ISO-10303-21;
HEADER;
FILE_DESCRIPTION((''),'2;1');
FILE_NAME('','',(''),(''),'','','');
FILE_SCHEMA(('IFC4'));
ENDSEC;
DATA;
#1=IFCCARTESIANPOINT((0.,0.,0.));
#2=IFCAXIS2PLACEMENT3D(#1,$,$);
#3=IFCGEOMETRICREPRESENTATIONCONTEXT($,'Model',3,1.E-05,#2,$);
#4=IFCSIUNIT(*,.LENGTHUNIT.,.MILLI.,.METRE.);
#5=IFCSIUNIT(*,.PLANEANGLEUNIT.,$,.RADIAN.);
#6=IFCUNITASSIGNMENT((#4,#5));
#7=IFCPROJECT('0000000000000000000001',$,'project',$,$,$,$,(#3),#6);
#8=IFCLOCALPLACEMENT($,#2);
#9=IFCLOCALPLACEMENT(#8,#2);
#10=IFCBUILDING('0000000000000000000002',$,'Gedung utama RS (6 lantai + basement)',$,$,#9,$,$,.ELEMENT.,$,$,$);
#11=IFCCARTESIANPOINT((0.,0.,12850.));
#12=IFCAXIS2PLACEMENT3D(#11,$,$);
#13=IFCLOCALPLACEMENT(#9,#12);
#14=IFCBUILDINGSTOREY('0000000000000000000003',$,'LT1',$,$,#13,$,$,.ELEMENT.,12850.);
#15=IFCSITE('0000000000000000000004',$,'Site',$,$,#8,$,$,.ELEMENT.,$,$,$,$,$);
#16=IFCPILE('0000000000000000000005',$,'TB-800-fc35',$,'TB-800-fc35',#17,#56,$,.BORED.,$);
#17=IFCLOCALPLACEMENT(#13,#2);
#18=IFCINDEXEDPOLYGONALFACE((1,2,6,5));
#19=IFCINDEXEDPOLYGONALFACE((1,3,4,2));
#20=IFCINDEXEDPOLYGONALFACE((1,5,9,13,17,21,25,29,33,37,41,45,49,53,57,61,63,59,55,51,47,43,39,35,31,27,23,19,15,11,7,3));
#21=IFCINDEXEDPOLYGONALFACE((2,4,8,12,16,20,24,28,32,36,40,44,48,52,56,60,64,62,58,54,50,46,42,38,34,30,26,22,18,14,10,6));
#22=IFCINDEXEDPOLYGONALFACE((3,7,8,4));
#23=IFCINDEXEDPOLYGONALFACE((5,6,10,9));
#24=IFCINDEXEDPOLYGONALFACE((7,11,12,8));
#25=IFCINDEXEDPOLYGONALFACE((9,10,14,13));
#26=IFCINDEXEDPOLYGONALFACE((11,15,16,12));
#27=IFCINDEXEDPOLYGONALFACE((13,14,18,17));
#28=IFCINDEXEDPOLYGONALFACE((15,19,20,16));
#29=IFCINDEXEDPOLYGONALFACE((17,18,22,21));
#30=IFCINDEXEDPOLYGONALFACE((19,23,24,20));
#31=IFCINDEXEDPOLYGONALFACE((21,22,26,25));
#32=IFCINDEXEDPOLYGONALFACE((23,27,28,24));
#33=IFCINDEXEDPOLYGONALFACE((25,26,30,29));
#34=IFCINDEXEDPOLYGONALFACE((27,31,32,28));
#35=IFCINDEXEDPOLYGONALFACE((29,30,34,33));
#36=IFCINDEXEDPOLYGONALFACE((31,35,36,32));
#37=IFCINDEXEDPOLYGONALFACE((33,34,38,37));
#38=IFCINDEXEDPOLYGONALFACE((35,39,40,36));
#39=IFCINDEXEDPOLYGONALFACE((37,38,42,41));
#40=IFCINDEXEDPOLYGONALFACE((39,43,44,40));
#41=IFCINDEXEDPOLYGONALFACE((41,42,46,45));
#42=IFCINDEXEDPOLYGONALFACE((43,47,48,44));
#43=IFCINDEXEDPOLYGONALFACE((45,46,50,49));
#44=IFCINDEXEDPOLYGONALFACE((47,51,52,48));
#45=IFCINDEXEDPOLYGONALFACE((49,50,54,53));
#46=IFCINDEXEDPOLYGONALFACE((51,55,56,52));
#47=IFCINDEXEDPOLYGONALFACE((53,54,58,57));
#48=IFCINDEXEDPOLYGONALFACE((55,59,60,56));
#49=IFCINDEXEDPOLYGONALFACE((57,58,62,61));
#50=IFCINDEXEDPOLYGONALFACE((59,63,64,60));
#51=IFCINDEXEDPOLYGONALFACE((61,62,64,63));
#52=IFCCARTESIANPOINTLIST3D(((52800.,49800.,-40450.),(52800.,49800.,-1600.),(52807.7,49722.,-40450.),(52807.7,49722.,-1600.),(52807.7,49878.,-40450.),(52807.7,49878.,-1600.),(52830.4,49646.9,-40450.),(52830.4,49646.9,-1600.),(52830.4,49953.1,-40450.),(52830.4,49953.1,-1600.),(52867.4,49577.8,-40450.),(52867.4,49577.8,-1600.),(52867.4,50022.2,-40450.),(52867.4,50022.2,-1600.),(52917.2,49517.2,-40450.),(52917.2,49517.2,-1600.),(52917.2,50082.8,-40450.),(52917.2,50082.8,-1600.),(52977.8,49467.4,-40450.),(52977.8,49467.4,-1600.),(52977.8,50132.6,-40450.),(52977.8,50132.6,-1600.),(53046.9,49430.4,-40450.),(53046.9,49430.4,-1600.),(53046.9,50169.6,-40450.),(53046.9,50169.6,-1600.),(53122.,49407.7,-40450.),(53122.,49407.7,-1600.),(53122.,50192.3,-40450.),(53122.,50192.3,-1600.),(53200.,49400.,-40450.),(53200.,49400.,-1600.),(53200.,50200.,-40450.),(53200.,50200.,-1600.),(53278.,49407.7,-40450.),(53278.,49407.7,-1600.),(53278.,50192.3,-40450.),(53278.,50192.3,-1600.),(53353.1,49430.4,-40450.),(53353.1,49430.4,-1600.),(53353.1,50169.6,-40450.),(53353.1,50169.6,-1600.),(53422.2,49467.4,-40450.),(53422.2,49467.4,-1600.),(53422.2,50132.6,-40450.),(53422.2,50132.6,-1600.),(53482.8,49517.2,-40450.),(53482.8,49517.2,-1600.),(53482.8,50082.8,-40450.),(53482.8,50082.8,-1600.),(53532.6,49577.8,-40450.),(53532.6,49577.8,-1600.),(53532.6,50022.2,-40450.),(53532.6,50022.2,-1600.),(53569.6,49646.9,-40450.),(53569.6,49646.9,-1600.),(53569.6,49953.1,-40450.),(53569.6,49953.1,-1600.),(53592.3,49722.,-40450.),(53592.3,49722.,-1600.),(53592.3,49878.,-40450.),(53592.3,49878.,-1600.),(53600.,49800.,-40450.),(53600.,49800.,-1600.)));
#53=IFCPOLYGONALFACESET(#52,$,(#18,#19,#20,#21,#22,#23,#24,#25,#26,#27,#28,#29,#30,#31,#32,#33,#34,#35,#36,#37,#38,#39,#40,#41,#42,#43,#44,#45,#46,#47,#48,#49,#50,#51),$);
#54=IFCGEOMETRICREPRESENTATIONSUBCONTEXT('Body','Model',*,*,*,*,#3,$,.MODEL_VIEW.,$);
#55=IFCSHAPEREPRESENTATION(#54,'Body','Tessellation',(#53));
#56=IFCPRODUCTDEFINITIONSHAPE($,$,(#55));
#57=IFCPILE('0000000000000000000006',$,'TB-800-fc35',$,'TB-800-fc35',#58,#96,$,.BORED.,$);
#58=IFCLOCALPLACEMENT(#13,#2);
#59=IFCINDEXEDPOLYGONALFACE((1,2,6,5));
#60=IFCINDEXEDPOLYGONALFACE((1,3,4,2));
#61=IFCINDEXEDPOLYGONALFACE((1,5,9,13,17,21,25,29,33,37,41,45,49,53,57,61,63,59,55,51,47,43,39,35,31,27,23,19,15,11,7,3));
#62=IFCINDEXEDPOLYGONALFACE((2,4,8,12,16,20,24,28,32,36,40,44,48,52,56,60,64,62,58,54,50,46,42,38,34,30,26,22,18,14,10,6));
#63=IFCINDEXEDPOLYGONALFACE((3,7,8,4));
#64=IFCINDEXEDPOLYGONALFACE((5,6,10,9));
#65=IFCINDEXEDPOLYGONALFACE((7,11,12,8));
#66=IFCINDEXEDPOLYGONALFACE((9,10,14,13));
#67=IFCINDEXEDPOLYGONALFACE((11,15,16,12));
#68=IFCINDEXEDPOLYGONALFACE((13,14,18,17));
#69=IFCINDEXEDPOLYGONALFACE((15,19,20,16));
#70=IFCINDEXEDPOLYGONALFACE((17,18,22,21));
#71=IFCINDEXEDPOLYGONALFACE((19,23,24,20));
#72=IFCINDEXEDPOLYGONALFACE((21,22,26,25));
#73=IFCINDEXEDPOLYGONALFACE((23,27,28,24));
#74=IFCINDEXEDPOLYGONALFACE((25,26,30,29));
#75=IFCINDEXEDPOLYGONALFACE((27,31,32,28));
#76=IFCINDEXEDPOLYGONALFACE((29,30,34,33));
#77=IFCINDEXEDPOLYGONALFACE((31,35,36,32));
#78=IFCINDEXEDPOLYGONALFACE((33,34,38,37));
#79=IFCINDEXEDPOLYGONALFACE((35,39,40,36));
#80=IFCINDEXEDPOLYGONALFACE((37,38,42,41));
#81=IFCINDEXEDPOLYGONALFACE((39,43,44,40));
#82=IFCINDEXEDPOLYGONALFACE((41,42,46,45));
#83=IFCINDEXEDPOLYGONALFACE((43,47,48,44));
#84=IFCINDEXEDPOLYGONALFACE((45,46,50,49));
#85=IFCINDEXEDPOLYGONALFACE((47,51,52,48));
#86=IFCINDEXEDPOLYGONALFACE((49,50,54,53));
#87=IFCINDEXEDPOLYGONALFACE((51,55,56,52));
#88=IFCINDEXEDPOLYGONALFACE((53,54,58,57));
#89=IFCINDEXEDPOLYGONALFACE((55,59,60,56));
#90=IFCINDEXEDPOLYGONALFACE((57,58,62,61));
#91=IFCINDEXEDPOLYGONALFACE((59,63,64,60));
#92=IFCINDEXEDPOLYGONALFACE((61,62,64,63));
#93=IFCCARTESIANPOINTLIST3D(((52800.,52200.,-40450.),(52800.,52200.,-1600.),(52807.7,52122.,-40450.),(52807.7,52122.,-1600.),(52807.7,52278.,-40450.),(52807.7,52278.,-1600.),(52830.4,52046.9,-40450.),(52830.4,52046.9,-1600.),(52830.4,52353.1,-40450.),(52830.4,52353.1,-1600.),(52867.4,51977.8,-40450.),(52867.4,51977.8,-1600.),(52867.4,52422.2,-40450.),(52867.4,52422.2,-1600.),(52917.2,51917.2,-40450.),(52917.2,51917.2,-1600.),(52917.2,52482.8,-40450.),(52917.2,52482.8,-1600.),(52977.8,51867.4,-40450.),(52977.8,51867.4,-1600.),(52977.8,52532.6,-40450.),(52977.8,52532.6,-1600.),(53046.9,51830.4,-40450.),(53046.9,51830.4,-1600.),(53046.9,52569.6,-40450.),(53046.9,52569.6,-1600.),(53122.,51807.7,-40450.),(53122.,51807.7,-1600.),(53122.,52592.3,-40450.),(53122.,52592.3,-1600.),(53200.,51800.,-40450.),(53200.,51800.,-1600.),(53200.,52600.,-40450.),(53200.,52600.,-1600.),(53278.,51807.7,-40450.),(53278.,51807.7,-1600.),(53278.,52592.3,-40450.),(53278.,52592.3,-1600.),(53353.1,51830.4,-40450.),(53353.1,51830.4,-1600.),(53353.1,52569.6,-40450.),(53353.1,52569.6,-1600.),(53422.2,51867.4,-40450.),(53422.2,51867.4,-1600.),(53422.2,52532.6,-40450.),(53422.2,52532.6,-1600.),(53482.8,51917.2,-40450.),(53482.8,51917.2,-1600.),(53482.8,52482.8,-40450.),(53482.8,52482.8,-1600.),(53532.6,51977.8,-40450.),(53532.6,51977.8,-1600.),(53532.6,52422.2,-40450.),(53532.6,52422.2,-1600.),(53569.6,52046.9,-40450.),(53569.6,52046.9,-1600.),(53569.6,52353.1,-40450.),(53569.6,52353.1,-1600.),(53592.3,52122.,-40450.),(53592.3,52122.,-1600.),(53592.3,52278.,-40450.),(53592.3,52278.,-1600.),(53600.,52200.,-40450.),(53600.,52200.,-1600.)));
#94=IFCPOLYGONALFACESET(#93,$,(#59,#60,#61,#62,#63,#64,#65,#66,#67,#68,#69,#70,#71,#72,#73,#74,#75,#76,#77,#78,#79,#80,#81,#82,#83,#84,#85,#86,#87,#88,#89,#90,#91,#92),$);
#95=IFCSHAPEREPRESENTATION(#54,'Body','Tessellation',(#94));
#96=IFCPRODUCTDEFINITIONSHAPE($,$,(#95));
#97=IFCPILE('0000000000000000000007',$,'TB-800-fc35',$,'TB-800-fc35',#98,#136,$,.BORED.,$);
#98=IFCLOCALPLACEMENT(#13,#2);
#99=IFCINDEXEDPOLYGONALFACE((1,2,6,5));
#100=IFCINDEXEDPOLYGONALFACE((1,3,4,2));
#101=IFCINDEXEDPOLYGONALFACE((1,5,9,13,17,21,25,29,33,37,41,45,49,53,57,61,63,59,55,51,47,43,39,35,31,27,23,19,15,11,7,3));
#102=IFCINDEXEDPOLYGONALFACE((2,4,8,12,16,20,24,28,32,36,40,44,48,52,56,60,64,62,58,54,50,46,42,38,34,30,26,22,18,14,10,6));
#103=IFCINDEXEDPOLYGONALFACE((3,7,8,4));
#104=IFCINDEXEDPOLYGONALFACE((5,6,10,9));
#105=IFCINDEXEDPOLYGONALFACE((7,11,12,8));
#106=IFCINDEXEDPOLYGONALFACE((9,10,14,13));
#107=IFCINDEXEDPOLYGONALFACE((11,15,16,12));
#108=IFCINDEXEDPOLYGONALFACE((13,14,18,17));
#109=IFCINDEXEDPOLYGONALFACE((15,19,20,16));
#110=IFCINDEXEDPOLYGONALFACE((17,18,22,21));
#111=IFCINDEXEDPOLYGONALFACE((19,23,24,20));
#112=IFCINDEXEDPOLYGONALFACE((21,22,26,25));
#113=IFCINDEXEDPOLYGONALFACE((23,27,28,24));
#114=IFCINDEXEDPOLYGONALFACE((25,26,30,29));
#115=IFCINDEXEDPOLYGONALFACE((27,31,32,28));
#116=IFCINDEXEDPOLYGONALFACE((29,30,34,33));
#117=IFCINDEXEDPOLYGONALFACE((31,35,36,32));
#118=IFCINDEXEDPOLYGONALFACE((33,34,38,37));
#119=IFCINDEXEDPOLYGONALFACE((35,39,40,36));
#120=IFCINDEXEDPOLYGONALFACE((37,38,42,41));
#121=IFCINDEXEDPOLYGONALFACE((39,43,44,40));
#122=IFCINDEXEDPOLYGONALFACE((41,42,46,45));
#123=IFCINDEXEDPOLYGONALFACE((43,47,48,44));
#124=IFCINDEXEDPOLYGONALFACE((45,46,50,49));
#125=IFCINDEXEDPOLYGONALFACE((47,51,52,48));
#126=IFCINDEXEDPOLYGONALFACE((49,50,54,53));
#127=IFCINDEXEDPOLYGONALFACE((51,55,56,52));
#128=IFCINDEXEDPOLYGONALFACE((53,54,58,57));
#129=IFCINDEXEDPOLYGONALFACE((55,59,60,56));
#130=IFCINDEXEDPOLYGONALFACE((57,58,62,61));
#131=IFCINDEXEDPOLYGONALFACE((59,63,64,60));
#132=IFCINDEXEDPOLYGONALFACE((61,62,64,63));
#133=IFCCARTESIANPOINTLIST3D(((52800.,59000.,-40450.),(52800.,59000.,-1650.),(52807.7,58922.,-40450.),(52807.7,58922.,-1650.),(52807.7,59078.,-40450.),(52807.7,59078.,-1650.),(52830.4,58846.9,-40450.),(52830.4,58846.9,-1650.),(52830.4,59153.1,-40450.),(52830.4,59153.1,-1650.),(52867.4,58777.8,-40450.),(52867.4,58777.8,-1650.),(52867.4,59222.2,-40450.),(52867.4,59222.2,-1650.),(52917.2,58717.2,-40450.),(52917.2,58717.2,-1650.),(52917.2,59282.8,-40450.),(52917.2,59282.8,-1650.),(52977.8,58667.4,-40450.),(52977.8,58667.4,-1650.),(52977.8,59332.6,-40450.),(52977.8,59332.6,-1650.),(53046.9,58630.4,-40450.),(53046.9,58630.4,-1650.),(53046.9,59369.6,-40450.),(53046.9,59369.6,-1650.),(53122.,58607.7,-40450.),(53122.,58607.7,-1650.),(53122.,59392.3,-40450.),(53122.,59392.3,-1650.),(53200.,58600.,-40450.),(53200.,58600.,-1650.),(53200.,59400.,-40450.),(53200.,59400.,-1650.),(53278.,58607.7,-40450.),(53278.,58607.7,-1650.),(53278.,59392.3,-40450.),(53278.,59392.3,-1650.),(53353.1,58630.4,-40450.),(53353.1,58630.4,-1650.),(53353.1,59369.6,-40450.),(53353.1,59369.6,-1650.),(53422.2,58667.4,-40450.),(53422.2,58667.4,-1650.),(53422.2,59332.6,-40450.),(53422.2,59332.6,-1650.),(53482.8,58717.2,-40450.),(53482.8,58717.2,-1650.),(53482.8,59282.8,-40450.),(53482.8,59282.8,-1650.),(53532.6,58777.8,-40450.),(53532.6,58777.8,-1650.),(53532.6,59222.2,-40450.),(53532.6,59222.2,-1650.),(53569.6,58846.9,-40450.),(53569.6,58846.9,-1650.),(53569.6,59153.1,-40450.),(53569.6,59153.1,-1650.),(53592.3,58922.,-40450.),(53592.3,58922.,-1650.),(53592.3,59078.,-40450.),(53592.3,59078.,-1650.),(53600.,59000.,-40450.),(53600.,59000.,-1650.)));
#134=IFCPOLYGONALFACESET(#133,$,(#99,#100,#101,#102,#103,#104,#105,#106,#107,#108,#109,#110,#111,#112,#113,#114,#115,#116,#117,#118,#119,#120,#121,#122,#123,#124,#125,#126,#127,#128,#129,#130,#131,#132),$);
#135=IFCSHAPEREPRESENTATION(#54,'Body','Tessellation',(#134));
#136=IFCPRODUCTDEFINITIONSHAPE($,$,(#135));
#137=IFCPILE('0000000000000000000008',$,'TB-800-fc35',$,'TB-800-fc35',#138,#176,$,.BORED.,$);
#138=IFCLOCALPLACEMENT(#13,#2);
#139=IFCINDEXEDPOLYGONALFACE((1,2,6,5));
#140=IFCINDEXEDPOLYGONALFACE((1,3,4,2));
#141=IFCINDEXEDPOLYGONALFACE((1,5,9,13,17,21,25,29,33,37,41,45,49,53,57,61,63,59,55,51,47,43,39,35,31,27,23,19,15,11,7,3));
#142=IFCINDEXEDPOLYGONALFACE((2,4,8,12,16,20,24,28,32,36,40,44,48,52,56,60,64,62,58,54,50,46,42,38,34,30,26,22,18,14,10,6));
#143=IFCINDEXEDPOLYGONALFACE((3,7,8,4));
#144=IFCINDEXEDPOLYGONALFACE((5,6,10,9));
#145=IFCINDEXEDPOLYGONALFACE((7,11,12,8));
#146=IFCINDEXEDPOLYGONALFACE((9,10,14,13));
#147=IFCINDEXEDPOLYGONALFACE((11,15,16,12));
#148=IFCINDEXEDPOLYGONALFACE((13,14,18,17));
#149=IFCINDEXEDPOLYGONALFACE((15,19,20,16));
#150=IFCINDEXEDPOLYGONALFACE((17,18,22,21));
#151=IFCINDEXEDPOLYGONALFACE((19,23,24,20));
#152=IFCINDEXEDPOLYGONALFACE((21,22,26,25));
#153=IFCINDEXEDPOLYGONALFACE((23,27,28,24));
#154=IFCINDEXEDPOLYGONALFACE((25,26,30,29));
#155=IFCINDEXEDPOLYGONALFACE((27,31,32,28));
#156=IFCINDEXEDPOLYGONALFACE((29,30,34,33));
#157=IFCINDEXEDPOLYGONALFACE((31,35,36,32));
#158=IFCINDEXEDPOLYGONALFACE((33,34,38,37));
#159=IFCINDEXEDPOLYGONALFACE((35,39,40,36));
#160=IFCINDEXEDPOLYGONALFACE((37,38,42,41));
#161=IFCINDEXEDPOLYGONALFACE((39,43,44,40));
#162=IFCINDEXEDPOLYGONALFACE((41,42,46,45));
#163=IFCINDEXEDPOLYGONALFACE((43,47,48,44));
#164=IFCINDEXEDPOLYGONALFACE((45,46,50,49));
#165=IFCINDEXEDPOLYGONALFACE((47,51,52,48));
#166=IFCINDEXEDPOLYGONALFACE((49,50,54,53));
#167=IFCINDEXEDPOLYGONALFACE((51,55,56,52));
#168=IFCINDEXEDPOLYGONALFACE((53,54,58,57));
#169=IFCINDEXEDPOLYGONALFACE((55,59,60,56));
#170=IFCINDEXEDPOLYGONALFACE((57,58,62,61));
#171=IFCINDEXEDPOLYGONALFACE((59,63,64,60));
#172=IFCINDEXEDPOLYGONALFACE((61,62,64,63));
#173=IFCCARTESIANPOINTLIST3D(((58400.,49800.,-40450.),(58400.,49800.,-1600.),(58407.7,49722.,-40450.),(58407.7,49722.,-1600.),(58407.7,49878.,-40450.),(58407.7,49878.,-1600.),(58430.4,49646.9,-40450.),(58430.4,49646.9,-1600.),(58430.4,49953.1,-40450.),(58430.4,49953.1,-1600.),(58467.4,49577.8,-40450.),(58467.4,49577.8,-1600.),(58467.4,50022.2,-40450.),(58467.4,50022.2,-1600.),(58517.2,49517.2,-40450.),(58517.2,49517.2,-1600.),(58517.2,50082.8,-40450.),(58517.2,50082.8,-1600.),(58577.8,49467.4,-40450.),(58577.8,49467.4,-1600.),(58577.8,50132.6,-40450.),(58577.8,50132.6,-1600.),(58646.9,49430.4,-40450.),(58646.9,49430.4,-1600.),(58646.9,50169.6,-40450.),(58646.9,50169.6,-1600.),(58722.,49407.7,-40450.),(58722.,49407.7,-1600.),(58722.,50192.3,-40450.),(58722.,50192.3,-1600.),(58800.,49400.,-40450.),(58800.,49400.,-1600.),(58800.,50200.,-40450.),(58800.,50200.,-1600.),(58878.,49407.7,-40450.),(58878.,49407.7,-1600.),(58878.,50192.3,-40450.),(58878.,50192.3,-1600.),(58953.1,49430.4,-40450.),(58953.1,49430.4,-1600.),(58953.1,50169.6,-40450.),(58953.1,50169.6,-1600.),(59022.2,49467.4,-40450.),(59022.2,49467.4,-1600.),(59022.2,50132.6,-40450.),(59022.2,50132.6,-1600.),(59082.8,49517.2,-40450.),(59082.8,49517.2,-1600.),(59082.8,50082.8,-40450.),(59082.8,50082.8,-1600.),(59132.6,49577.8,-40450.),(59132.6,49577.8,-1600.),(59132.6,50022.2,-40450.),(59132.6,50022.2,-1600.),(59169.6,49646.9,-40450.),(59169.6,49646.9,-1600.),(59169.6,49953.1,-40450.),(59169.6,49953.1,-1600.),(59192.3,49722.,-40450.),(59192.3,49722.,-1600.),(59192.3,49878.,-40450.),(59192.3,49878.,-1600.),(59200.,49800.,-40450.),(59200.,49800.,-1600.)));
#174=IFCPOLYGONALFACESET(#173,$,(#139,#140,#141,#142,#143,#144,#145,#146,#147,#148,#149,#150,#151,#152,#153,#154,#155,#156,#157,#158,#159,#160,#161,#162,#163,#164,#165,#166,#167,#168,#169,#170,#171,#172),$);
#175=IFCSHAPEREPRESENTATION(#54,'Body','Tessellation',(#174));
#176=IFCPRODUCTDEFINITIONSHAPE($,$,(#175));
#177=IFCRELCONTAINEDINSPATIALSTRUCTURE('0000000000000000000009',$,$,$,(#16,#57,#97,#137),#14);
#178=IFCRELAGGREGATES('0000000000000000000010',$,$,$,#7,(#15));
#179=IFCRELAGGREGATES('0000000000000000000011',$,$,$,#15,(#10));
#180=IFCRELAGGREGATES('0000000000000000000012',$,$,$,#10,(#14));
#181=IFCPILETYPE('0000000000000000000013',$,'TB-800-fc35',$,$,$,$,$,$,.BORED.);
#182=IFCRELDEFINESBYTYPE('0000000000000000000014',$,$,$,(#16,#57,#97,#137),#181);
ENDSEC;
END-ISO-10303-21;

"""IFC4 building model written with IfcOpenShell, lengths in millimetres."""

from ifc_helpers import new_model, si_unit, frame, origin, origin_2d, place, context, subcontext, project, spatial, circle, extrude, material_profile, profile_set, profile_usage, type_object, element, save


model = new_model("IFC4")

# Units and contexts
model_context = context("Model", 3, precision=1e-05, world=origin())
body_context = subcontext(model_context, "Body", "Model", "MODEL_VIEW")
ifc_project = project(units=[si_unit("LENGTHUNIT", "METRE", prefix="MILLI"), si_unit("PLANEANGLEUNIT", "RADIAN")], contexts=[model_context])

# Site, building, storey
site_placement = place(None, origin())
site = spatial("IfcSite", under=ifc_project, at=site_placement, Name="Site", CompositionType="ELEMENT")
building_placement = place(site_placement, origin())
building = spatial("IfcBuilding", under=site, at=building_placement, Name="Gedung utama RS (6 lantai + basement)", CompositionType="ELEMENT")
storey_placement = place(building_placement, frame((0.0, 0.0, 12850.0)))
storey = spatial("IfcBuildingStorey", under=building, at=storey_placement, Name="LT1", CompositionType="ELEMENT", Elevation=12850.0)

# Piles
ifc_material_profile = material_profile(None, circle(Radius=400.0, at=origin_2d()), Name="TB-800-fc35")
ifc_profile_set = profile_set([ifc_material_profile], Name="TB-800-fc35")
ifc_profile_usage = profile_usage(ifc_profile_set, cardinal=5)
pile_type = type_object("IfcPileType", Name="TB-800-fc35", PredefinedType="BORED", material=ifc_profile_set)
for number, where, z_axis, x_axis, name in (
    (1, (53200.0, 49800.0, -40450.0), (0.0, 0.0, 1.0), (1.0, 0.0, 0.0), "TB-800-fc35"),
    (2, (53200.0, 52200.0, -40450.0), (0.0, 0.0, 1.0), (1.0, 0.0, 0.0), "TB-800-fc35"),
):
    element("IfcPile", number, at=place(storey_placement, frame(where, z_axis=z_axis, x_axis=x_axis)), inside=storey, type_object=pile_type, material=ifc_profile_usage, Name=name, ObjectType="TB-800-fc35", PredefinedType="BORED", context=body_context, shape_type="SweptSolid", body=[
        extrude(circle(Radius=400.0, at=origin_2d()), origin(), (0.0, 0.0, 1.0), 38850.0),
    ])
pile_placement = place(storey_placement, frame((53200.0, 59000.0, -40450.0), z_axis=(0.0, 0.0, 1.0), x_axis=(1.0, 0.0, 0.0)))
element("IfcPile", 3, at=pile_placement, inside=storey, type_object=pile_type, material=ifc_profile_usage, Name="TB-800-fc35", ObjectType="TB-800-fc35", PredefinedType="BORED", context=body_context, shape_type="SweptSolid", body=[
    extrude(circle(Radius=400.0, at=origin_2d()), origin(), (0.0, 0.0, 1.0), 38800.0),
])
for number, where, z_axis, x_axis, name in (
    (4, (58800.0, 49800.0, -40450.0), (0.0, 0.0, 1.0), (1.0, 0.0, 0.0), "TB-800-fc35"),
):
    element("IfcPile", number, at=place(storey_placement, frame(where, z_axis=z_axis, x_axis=x_axis)), inside=storey, type_object=pile_type, material=ifc_profile_usage, Name=name, ObjectType="TB-800-fc35", PredefinedType="BORED", context=body_context, shape_type="SweptSolid", body=[
        extrude(circle(Radius=400.0, at=origin_2d()), origin(), (0.0, 0.0, 1.0), 38850.0),
    ])

save(model, "model.ifc")
